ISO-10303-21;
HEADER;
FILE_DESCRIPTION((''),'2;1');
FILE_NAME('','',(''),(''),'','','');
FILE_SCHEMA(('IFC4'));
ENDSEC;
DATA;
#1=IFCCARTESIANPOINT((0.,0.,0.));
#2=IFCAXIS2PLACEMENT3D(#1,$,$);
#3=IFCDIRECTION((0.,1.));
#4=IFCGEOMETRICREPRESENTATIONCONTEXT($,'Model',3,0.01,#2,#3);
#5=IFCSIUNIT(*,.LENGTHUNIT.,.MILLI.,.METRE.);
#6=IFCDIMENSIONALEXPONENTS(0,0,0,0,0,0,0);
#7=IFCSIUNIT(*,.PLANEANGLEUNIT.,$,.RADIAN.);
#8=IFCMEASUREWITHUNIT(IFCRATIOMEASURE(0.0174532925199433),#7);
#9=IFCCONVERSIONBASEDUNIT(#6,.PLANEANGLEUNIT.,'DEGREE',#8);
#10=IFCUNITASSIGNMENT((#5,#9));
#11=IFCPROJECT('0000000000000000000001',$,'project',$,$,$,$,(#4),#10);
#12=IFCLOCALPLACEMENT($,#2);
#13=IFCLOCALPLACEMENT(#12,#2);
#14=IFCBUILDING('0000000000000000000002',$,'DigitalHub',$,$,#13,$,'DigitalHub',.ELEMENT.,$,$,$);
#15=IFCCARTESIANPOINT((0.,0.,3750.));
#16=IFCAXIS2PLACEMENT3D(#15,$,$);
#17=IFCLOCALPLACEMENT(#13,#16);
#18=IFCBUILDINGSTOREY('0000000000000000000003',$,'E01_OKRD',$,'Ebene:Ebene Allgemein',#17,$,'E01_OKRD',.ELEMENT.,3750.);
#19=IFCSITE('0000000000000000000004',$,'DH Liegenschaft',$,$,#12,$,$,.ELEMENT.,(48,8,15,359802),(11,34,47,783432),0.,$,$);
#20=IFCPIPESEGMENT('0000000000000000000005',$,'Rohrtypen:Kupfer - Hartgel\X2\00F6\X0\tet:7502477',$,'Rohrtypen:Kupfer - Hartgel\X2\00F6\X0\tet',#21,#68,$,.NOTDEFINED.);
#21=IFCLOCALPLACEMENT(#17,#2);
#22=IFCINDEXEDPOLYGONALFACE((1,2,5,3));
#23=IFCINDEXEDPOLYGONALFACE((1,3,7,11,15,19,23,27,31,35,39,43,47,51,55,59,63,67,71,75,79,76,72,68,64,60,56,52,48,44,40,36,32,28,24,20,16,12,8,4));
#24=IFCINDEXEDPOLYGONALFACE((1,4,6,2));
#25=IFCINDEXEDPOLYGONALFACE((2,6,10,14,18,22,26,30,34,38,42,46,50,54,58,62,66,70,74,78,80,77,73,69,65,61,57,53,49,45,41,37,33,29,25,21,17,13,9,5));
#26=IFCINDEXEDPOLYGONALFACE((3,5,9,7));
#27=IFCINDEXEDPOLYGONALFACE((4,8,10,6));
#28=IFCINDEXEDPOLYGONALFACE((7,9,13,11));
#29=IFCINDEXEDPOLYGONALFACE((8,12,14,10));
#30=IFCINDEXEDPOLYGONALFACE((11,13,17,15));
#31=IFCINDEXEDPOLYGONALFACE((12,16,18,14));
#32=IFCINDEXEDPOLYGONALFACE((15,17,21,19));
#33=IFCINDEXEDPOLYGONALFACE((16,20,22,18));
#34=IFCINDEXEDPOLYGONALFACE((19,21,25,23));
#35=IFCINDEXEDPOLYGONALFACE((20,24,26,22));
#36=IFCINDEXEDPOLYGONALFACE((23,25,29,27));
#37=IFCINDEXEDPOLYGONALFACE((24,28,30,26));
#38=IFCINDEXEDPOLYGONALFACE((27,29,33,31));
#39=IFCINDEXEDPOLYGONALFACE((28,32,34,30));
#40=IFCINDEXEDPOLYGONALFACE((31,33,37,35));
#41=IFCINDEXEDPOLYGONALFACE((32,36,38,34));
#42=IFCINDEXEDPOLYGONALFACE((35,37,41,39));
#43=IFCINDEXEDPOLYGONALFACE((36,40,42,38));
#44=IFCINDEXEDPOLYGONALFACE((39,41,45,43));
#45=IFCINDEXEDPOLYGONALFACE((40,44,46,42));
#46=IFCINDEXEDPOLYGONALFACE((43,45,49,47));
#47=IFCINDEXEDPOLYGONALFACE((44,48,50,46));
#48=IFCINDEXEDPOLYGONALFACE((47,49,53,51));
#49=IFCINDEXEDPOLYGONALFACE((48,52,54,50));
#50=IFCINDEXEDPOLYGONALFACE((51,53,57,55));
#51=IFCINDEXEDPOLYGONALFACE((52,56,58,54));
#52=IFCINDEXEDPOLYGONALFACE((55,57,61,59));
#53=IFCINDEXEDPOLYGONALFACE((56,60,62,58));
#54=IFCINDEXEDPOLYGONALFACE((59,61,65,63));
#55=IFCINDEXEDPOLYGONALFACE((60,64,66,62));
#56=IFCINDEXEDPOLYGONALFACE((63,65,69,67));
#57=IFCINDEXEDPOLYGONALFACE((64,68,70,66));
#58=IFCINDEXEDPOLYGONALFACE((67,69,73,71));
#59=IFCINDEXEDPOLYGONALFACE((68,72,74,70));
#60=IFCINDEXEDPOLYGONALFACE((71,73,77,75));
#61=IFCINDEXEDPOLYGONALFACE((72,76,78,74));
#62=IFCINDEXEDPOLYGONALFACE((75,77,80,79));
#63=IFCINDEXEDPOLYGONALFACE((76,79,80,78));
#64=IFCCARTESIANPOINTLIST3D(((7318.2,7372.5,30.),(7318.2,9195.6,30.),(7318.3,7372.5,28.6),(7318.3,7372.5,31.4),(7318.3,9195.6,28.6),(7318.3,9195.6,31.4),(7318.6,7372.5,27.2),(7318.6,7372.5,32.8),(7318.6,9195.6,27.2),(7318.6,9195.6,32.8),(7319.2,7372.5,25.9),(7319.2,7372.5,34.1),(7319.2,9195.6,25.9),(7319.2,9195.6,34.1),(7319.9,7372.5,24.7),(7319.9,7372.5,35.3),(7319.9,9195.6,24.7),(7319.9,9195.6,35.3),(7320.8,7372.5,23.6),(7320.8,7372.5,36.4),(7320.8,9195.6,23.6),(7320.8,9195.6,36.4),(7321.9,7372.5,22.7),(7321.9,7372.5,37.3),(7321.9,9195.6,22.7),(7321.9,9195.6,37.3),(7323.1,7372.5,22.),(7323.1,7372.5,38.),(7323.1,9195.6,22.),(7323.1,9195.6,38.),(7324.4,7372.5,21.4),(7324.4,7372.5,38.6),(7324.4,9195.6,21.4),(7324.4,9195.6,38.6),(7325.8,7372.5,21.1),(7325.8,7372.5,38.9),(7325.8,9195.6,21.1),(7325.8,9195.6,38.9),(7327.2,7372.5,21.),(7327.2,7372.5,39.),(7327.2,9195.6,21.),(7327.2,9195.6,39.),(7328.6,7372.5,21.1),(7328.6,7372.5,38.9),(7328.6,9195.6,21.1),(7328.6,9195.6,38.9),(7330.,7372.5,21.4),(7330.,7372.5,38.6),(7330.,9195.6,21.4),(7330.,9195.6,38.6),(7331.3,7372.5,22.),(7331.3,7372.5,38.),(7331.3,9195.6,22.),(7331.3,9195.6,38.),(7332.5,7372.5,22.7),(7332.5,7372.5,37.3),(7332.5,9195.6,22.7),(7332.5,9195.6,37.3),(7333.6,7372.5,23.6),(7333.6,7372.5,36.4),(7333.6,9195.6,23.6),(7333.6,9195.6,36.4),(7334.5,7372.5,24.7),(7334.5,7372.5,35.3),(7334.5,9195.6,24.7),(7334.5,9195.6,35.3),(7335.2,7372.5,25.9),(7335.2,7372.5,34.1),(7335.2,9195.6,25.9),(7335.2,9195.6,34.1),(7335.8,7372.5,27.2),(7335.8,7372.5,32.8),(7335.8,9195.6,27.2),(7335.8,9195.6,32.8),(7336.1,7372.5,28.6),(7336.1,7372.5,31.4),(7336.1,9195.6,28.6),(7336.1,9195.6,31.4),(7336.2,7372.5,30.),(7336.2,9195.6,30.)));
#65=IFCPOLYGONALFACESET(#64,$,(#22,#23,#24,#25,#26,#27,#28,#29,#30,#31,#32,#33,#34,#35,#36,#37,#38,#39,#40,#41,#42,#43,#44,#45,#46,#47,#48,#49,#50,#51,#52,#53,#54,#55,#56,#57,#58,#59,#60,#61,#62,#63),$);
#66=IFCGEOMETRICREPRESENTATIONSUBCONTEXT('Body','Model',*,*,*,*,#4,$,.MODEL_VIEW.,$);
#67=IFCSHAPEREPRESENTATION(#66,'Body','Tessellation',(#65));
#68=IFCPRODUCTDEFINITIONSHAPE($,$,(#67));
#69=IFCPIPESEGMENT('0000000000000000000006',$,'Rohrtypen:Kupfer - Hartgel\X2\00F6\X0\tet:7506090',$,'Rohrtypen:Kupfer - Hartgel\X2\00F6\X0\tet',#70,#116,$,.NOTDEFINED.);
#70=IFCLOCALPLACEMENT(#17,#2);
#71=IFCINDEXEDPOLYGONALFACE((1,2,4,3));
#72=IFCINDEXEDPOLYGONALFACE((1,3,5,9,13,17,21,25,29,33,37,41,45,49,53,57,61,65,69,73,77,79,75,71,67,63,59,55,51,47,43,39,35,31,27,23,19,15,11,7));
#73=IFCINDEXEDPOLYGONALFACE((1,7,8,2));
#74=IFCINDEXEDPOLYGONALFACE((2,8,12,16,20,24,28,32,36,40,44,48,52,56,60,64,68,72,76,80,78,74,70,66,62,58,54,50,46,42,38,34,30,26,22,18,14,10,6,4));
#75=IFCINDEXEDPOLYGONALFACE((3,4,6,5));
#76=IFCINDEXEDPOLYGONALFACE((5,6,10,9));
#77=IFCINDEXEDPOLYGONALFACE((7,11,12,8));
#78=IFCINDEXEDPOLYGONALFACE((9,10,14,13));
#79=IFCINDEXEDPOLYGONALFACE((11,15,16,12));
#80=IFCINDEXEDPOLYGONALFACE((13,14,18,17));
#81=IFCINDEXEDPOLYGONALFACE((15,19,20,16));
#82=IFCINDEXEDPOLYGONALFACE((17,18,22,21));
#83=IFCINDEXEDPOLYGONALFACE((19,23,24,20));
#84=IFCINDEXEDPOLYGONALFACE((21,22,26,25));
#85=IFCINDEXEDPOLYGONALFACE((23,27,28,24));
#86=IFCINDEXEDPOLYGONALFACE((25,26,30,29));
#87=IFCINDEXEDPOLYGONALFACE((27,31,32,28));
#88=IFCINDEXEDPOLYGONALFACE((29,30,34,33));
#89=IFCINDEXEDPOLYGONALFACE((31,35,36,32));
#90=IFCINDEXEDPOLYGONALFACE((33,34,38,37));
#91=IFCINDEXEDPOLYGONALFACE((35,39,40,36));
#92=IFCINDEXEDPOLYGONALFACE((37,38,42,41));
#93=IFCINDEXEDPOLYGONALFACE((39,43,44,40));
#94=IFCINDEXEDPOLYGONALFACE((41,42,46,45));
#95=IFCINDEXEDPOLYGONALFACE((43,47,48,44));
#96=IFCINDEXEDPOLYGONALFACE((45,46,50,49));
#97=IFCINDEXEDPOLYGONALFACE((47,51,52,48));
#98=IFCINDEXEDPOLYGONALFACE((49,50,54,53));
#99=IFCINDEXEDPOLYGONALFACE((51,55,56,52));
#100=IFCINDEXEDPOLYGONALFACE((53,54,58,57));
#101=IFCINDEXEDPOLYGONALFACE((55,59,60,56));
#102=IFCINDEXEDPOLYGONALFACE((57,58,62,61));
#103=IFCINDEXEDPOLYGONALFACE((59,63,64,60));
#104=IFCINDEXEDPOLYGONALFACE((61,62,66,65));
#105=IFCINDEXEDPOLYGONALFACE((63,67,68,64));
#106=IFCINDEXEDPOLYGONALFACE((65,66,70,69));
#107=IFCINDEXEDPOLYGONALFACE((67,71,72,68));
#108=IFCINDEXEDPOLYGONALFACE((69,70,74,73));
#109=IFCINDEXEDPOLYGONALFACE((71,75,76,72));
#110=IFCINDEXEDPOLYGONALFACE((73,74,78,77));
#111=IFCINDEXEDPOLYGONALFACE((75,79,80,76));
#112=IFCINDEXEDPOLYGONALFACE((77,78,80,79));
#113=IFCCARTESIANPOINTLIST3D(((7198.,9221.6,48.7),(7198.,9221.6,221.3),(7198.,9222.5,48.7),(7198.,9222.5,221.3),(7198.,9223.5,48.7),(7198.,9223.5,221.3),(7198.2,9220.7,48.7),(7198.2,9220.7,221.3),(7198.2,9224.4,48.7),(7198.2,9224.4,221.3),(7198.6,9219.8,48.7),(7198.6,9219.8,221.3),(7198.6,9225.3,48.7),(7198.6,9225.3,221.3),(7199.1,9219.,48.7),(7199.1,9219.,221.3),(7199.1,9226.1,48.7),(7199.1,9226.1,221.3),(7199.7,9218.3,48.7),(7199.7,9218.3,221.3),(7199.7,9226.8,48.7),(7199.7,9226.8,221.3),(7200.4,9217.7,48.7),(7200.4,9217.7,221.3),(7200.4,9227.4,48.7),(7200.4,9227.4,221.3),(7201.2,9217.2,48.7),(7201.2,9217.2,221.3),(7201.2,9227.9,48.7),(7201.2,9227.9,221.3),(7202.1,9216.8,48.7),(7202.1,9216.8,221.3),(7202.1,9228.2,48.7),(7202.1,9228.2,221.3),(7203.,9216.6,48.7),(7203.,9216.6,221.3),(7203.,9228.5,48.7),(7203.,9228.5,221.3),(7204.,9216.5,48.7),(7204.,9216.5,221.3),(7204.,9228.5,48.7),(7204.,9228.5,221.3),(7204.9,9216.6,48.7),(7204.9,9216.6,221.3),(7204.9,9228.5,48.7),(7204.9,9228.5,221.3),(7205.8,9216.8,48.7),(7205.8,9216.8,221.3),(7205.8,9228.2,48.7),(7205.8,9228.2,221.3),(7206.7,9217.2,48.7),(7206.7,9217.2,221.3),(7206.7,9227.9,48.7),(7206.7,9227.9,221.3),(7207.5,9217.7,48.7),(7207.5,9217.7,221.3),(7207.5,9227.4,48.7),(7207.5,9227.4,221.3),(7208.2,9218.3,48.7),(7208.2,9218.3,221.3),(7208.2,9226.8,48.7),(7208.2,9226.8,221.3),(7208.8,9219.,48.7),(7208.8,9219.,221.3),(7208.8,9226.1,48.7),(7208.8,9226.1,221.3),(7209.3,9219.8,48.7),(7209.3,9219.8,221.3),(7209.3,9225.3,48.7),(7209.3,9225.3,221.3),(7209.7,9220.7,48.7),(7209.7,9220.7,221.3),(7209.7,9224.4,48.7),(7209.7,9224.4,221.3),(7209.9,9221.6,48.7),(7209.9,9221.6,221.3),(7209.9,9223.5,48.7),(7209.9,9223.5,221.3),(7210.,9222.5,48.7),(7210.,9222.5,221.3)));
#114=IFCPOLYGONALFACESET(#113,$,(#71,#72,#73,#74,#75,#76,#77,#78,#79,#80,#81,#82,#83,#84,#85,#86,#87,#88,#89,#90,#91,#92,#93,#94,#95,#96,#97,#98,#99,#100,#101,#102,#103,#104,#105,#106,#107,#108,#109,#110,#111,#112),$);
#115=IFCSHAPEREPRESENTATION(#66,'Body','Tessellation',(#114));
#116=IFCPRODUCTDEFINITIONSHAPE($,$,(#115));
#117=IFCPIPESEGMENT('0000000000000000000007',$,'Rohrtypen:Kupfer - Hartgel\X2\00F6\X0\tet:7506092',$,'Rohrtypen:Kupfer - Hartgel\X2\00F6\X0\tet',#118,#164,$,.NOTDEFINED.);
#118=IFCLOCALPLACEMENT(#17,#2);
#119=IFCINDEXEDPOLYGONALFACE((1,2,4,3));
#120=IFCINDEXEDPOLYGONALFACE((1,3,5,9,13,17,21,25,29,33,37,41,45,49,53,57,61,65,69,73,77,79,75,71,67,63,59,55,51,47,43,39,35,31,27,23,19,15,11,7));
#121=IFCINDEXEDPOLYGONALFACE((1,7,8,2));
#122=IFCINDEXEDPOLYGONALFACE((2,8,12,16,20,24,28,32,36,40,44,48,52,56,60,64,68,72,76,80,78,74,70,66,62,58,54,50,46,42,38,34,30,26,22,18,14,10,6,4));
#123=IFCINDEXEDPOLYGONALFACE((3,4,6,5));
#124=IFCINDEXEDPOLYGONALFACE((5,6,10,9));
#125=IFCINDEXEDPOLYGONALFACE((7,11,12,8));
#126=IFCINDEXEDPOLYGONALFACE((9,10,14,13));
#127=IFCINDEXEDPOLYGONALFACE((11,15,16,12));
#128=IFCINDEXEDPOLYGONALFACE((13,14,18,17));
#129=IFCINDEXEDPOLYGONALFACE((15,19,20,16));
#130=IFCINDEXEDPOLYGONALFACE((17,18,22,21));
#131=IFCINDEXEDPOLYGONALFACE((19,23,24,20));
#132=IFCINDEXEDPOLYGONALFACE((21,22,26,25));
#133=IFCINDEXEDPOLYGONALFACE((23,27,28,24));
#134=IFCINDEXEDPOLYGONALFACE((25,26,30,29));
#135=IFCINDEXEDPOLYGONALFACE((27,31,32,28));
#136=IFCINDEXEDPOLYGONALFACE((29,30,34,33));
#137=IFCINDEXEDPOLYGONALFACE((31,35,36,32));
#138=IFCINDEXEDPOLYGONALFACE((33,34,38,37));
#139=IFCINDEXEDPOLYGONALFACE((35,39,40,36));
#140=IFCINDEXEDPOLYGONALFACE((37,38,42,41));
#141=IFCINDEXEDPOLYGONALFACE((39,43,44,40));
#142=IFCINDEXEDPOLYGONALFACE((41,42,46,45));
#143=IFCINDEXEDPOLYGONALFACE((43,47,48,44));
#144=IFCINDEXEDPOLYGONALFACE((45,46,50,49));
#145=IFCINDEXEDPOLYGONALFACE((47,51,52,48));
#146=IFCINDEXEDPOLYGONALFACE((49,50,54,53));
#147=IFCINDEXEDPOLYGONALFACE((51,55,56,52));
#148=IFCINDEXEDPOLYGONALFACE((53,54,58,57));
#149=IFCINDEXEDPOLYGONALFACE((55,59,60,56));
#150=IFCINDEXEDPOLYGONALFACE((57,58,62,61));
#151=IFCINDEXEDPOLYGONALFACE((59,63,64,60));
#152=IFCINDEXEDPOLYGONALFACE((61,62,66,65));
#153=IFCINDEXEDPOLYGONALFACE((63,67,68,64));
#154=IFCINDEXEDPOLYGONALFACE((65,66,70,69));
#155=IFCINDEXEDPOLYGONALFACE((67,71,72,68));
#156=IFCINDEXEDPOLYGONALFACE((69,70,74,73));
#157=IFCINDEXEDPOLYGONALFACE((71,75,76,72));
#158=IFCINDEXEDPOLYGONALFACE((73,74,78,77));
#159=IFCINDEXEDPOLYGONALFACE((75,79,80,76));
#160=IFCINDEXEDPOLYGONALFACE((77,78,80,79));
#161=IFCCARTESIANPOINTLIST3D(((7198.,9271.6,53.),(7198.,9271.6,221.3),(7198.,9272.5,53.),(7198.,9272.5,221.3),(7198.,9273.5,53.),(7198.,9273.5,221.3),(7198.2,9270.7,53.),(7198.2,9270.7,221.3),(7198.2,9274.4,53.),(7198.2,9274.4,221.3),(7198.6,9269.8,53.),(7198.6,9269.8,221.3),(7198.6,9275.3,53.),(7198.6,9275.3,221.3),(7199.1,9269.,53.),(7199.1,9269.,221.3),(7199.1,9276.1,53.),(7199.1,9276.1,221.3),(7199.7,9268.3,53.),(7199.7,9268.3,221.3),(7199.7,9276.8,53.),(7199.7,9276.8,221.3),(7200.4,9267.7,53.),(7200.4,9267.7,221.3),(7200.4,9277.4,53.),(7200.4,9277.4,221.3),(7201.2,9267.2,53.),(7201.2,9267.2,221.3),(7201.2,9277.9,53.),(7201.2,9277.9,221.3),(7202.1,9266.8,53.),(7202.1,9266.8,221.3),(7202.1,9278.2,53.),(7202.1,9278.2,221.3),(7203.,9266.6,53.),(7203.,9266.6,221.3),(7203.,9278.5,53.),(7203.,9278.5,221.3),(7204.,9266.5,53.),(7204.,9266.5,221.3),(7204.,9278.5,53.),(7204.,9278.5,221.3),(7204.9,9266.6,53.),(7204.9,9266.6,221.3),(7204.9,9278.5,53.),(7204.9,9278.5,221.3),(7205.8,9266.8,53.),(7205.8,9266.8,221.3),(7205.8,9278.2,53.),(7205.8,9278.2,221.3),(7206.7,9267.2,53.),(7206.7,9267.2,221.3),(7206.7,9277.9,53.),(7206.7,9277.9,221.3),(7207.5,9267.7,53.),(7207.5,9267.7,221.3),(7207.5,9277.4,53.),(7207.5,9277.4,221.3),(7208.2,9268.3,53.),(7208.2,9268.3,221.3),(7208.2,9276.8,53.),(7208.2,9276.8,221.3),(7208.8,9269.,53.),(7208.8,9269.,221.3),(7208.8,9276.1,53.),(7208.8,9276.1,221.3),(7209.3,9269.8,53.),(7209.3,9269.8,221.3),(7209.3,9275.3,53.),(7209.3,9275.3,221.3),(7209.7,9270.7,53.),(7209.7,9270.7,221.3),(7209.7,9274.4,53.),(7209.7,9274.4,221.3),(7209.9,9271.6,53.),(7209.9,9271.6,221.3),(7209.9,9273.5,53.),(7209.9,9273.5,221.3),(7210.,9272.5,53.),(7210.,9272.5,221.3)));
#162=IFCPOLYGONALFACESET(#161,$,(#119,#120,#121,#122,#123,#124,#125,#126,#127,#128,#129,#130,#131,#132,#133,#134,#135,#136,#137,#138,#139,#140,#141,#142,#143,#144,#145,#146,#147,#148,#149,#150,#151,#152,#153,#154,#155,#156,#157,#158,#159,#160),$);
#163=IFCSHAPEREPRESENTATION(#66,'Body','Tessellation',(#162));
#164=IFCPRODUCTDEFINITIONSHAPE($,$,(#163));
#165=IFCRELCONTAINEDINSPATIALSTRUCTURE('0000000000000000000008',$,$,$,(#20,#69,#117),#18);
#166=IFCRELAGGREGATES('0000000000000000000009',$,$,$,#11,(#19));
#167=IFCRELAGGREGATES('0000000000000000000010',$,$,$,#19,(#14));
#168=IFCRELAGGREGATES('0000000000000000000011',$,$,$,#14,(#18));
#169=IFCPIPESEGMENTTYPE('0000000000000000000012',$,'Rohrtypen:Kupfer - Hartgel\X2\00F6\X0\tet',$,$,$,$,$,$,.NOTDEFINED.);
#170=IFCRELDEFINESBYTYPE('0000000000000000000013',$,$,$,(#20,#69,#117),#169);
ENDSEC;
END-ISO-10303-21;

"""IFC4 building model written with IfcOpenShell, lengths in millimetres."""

from ifc_helpers import new_model, entity, si_unit, converted_unit, direction, frame, origin, place, context, subcontext, project, spatial, indexed_curve, outline, extrude, type_object, element, save


model = new_model("IFC4")

# Units and contexts
model_context = context("Model", 3, precision=0.01, world=origin(), true_north=direction((0.0, 1.0)))
body_context = subcontext(model_context, "Body", "Model", "MODEL_VIEW")
ifc_project = project(units=[si_unit("LENGTHUNIT", "METRE", prefix="MILLI"), converted_unit("PLANEANGLEUNIT", "DEGREE", entity("IfcRatioMeasure", 0.0174532925199433), si_unit("PLANEANGLEUNIT", "RADIAN"), dimensions=[0, 0, 0, 0, 0, 0, 0])], contexts=[model_context])

# Site, building, storey
site_placement = place(None, origin())
site = spatial("IfcSite", under=ifc_project, at=site_placement, Name="DH Liegenschaft", CompositionType="ELEMENT", RefLatitude=(48, 8, 15, 359802), RefLongitude=(11, 34, 47, 783432), RefElevation=0.0)
building_placement = place(site_placement, origin())
building = spatial("IfcBuilding", under=site, at=building_placement, Name="DigitalHub", LongName="DigitalHub", CompositionType="ELEMENT")
storey_placement = place(building_placement, frame((0.0, 0.0, 3750.0)))
storey = spatial("IfcBuildingStorey", under=building, at=storey_placement, Name="E01_OKRD", ObjectType="Ebene:Ebene Allgemein", LongName="E01_OKRD", CompositionType="ELEMENT", Elevation=3750.0)

# Pipe segments
pipe_segment_type = type_object("IfcPipeSegmentType", Name="Rohrtypen:Kupfer - Hartgelötet", PredefinedType="NOTDEFINED")
pipe_segment_1_placement = place(storey_placement, frame((7316.6, 7372.5, 19.4)))
element("IfcPipeSegment", 1, at=pipe_segment_1_placement, inside=storey, type_object=pipe_segment_type, Name="Rohrtypen:Kupfer - Hartgelötet:7502477", ObjectType="Rohrtypen:Kupfer - Hartgelötet", PredefinedType="NOTDEFINED", context=body_context, shape_type="SweptSolid", body=[
    extrude(outline(indexed_curve([(9.0, 0.0), (8.9, 1.4), (8.6, 2.8), (8.0, 4.1), (7.3, 5.3), (6.4, 6.4), (5.3, 7.3), (4.1, 8.0), (2.8, 8.6), (1.4, 8.9), (0.0, 9.0), (-1.4, 8.9), (-2.8, 8.6), (-4.1, 8.0), (-5.3, 7.3), (-6.4, 6.4), (-7.3, 5.3), (-8.0, 4.1), (-8.6, 2.8), (-8.9, 1.4), (-9.0, 0.0), (-8.9, -1.4), (-8.6, -2.8), (-8.0, -4.1), (-7.3, -5.3), (-6.4, -6.4), (-5.3, -7.3), (-4.1, -8.0), (-2.8, -8.6), (-1.4, -8.9), (0.0, -9.0), (1.4, -8.9), (2.8, -8.6), (4.1, -8.0), (5.3, -7.3), (6.4, -6.4), (7.3, -5.3), (8.0, -4.1), (8.6, -2.8), (8.9, -1.4), (9.0, 0.0)], self_intersect=False)), frame((10.6, 0.0, 10.6), z_axis=(0.0, 1.0, 0.0), x_axis=(-1.0, 0.0, 0.0)), (0.0, 0.0, 1.0), 1823.1),
])
pipe_segment_2_placement = place(storey_placement, frame((7196.4, 9214.9, 48.7)))
element("IfcPipeSegment", 2, at=pipe_segment_2_placement, inside=storey, type_object=pipe_segment_type, Name="Rohrtypen:Kupfer - Hartgelötet:7506090", ObjectType="Rohrtypen:Kupfer - Hartgelötet", PredefinedType="NOTDEFINED", context=body_context, shape_type="SweptSolid", body=[
    extrude(outline(indexed_curve([(6.0, 0.0), (5.9, 0.9), (5.7, 1.9), (5.3, 2.7), (4.9, 3.5), (4.2, 4.2), (3.5, 4.9), (2.7, 5.3), (1.9, 5.7), (0.9, 5.9), (0.0, 6.0), (-0.9, 5.9), (-1.9, 5.7), (-2.7, 5.3), (-3.5, 4.9), (-4.2, 4.2), (-4.9, 3.5), (-5.3, 2.7), (-5.7, 1.9), (-5.9, 0.9), (-6.0, 0.0), (-5.9, -0.9), (-5.7, -1.9), (-5.3, -2.7), (-4.9, -3.5), (-4.2, -4.2), (-3.5, -4.9), (-2.7, -5.3), (-1.9, -5.7), (-0.9, -5.9), (0.0, -6.0), (0.9, -5.9), (1.9, -5.7), (2.7, -5.3), (3.5, -4.9), (4.2, -4.2), (4.9, -3.5), (5.3, -2.7), (5.7, -1.9), (5.9, -0.9), (6.0, 0.0)], self_intersect=False)), frame((7.6, 7.6, 0.0)), (0.0, 0.0, 1.0), 172.6),
])
pipe_segment_3_placement = place(storey_placement, frame((7196.4, 9264.9, 53.0)))
element("IfcPipeSegment", 3, at=pipe_segment_3_placement, inside=storey, type_object=pipe_segment_type, Name="Rohrtypen:Kupfer - Hartgelötet:7506092", ObjectType="Rohrtypen:Kupfer - Hartgelötet", PredefinedType="NOTDEFINED", context=body_context, shape_type="SweptSolid", body=[
    extrude(outline(indexed_curve([(6.0, 0.0), (5.9, 0.9), (5.7, 1.9), (5.3, 2.7), (4.9, 3.5), (4.2, 4.2), (3.5, 4.9), (2.7, 5.3), (1.9, 5.7), (0.9, 5.9), (0.0, 6.0), (-0.9, 5.9), (-1.9, 5.7), (-2.7, 5.3), (-3.5, 4.9), (-4.2, 4.2), (-4.9, 3.5), (-5.3, 2.7), (-5.7, 1.9), (-5.9, 0.9), (-6.0, 0.0), (-5.9, -0.9), (-5.7, -1.9), (-5.3, -2.7), (-4.9, -3.5), (-4.2, -4.2), (-3.5, -4.9), (-2.7, -5.3), (-1.9, -5.7), (-0.9, -5.9), (0.0, -6.0), (0.9, -5.9), (1.9, -5.7), (2.7, -5.3), (3.5, -4.9), (4.2, -4.2), (4.9, -3.5), (5.3, -2.7), (5.7, -1.9), (5.9, -0.9), (6.0, 0.0)], self_intersect=False)), frame((7.6, 7.6, 0.0)), (0.0, 0.0, 1.0), 168.3),
])

save(model, "model.ifc")
